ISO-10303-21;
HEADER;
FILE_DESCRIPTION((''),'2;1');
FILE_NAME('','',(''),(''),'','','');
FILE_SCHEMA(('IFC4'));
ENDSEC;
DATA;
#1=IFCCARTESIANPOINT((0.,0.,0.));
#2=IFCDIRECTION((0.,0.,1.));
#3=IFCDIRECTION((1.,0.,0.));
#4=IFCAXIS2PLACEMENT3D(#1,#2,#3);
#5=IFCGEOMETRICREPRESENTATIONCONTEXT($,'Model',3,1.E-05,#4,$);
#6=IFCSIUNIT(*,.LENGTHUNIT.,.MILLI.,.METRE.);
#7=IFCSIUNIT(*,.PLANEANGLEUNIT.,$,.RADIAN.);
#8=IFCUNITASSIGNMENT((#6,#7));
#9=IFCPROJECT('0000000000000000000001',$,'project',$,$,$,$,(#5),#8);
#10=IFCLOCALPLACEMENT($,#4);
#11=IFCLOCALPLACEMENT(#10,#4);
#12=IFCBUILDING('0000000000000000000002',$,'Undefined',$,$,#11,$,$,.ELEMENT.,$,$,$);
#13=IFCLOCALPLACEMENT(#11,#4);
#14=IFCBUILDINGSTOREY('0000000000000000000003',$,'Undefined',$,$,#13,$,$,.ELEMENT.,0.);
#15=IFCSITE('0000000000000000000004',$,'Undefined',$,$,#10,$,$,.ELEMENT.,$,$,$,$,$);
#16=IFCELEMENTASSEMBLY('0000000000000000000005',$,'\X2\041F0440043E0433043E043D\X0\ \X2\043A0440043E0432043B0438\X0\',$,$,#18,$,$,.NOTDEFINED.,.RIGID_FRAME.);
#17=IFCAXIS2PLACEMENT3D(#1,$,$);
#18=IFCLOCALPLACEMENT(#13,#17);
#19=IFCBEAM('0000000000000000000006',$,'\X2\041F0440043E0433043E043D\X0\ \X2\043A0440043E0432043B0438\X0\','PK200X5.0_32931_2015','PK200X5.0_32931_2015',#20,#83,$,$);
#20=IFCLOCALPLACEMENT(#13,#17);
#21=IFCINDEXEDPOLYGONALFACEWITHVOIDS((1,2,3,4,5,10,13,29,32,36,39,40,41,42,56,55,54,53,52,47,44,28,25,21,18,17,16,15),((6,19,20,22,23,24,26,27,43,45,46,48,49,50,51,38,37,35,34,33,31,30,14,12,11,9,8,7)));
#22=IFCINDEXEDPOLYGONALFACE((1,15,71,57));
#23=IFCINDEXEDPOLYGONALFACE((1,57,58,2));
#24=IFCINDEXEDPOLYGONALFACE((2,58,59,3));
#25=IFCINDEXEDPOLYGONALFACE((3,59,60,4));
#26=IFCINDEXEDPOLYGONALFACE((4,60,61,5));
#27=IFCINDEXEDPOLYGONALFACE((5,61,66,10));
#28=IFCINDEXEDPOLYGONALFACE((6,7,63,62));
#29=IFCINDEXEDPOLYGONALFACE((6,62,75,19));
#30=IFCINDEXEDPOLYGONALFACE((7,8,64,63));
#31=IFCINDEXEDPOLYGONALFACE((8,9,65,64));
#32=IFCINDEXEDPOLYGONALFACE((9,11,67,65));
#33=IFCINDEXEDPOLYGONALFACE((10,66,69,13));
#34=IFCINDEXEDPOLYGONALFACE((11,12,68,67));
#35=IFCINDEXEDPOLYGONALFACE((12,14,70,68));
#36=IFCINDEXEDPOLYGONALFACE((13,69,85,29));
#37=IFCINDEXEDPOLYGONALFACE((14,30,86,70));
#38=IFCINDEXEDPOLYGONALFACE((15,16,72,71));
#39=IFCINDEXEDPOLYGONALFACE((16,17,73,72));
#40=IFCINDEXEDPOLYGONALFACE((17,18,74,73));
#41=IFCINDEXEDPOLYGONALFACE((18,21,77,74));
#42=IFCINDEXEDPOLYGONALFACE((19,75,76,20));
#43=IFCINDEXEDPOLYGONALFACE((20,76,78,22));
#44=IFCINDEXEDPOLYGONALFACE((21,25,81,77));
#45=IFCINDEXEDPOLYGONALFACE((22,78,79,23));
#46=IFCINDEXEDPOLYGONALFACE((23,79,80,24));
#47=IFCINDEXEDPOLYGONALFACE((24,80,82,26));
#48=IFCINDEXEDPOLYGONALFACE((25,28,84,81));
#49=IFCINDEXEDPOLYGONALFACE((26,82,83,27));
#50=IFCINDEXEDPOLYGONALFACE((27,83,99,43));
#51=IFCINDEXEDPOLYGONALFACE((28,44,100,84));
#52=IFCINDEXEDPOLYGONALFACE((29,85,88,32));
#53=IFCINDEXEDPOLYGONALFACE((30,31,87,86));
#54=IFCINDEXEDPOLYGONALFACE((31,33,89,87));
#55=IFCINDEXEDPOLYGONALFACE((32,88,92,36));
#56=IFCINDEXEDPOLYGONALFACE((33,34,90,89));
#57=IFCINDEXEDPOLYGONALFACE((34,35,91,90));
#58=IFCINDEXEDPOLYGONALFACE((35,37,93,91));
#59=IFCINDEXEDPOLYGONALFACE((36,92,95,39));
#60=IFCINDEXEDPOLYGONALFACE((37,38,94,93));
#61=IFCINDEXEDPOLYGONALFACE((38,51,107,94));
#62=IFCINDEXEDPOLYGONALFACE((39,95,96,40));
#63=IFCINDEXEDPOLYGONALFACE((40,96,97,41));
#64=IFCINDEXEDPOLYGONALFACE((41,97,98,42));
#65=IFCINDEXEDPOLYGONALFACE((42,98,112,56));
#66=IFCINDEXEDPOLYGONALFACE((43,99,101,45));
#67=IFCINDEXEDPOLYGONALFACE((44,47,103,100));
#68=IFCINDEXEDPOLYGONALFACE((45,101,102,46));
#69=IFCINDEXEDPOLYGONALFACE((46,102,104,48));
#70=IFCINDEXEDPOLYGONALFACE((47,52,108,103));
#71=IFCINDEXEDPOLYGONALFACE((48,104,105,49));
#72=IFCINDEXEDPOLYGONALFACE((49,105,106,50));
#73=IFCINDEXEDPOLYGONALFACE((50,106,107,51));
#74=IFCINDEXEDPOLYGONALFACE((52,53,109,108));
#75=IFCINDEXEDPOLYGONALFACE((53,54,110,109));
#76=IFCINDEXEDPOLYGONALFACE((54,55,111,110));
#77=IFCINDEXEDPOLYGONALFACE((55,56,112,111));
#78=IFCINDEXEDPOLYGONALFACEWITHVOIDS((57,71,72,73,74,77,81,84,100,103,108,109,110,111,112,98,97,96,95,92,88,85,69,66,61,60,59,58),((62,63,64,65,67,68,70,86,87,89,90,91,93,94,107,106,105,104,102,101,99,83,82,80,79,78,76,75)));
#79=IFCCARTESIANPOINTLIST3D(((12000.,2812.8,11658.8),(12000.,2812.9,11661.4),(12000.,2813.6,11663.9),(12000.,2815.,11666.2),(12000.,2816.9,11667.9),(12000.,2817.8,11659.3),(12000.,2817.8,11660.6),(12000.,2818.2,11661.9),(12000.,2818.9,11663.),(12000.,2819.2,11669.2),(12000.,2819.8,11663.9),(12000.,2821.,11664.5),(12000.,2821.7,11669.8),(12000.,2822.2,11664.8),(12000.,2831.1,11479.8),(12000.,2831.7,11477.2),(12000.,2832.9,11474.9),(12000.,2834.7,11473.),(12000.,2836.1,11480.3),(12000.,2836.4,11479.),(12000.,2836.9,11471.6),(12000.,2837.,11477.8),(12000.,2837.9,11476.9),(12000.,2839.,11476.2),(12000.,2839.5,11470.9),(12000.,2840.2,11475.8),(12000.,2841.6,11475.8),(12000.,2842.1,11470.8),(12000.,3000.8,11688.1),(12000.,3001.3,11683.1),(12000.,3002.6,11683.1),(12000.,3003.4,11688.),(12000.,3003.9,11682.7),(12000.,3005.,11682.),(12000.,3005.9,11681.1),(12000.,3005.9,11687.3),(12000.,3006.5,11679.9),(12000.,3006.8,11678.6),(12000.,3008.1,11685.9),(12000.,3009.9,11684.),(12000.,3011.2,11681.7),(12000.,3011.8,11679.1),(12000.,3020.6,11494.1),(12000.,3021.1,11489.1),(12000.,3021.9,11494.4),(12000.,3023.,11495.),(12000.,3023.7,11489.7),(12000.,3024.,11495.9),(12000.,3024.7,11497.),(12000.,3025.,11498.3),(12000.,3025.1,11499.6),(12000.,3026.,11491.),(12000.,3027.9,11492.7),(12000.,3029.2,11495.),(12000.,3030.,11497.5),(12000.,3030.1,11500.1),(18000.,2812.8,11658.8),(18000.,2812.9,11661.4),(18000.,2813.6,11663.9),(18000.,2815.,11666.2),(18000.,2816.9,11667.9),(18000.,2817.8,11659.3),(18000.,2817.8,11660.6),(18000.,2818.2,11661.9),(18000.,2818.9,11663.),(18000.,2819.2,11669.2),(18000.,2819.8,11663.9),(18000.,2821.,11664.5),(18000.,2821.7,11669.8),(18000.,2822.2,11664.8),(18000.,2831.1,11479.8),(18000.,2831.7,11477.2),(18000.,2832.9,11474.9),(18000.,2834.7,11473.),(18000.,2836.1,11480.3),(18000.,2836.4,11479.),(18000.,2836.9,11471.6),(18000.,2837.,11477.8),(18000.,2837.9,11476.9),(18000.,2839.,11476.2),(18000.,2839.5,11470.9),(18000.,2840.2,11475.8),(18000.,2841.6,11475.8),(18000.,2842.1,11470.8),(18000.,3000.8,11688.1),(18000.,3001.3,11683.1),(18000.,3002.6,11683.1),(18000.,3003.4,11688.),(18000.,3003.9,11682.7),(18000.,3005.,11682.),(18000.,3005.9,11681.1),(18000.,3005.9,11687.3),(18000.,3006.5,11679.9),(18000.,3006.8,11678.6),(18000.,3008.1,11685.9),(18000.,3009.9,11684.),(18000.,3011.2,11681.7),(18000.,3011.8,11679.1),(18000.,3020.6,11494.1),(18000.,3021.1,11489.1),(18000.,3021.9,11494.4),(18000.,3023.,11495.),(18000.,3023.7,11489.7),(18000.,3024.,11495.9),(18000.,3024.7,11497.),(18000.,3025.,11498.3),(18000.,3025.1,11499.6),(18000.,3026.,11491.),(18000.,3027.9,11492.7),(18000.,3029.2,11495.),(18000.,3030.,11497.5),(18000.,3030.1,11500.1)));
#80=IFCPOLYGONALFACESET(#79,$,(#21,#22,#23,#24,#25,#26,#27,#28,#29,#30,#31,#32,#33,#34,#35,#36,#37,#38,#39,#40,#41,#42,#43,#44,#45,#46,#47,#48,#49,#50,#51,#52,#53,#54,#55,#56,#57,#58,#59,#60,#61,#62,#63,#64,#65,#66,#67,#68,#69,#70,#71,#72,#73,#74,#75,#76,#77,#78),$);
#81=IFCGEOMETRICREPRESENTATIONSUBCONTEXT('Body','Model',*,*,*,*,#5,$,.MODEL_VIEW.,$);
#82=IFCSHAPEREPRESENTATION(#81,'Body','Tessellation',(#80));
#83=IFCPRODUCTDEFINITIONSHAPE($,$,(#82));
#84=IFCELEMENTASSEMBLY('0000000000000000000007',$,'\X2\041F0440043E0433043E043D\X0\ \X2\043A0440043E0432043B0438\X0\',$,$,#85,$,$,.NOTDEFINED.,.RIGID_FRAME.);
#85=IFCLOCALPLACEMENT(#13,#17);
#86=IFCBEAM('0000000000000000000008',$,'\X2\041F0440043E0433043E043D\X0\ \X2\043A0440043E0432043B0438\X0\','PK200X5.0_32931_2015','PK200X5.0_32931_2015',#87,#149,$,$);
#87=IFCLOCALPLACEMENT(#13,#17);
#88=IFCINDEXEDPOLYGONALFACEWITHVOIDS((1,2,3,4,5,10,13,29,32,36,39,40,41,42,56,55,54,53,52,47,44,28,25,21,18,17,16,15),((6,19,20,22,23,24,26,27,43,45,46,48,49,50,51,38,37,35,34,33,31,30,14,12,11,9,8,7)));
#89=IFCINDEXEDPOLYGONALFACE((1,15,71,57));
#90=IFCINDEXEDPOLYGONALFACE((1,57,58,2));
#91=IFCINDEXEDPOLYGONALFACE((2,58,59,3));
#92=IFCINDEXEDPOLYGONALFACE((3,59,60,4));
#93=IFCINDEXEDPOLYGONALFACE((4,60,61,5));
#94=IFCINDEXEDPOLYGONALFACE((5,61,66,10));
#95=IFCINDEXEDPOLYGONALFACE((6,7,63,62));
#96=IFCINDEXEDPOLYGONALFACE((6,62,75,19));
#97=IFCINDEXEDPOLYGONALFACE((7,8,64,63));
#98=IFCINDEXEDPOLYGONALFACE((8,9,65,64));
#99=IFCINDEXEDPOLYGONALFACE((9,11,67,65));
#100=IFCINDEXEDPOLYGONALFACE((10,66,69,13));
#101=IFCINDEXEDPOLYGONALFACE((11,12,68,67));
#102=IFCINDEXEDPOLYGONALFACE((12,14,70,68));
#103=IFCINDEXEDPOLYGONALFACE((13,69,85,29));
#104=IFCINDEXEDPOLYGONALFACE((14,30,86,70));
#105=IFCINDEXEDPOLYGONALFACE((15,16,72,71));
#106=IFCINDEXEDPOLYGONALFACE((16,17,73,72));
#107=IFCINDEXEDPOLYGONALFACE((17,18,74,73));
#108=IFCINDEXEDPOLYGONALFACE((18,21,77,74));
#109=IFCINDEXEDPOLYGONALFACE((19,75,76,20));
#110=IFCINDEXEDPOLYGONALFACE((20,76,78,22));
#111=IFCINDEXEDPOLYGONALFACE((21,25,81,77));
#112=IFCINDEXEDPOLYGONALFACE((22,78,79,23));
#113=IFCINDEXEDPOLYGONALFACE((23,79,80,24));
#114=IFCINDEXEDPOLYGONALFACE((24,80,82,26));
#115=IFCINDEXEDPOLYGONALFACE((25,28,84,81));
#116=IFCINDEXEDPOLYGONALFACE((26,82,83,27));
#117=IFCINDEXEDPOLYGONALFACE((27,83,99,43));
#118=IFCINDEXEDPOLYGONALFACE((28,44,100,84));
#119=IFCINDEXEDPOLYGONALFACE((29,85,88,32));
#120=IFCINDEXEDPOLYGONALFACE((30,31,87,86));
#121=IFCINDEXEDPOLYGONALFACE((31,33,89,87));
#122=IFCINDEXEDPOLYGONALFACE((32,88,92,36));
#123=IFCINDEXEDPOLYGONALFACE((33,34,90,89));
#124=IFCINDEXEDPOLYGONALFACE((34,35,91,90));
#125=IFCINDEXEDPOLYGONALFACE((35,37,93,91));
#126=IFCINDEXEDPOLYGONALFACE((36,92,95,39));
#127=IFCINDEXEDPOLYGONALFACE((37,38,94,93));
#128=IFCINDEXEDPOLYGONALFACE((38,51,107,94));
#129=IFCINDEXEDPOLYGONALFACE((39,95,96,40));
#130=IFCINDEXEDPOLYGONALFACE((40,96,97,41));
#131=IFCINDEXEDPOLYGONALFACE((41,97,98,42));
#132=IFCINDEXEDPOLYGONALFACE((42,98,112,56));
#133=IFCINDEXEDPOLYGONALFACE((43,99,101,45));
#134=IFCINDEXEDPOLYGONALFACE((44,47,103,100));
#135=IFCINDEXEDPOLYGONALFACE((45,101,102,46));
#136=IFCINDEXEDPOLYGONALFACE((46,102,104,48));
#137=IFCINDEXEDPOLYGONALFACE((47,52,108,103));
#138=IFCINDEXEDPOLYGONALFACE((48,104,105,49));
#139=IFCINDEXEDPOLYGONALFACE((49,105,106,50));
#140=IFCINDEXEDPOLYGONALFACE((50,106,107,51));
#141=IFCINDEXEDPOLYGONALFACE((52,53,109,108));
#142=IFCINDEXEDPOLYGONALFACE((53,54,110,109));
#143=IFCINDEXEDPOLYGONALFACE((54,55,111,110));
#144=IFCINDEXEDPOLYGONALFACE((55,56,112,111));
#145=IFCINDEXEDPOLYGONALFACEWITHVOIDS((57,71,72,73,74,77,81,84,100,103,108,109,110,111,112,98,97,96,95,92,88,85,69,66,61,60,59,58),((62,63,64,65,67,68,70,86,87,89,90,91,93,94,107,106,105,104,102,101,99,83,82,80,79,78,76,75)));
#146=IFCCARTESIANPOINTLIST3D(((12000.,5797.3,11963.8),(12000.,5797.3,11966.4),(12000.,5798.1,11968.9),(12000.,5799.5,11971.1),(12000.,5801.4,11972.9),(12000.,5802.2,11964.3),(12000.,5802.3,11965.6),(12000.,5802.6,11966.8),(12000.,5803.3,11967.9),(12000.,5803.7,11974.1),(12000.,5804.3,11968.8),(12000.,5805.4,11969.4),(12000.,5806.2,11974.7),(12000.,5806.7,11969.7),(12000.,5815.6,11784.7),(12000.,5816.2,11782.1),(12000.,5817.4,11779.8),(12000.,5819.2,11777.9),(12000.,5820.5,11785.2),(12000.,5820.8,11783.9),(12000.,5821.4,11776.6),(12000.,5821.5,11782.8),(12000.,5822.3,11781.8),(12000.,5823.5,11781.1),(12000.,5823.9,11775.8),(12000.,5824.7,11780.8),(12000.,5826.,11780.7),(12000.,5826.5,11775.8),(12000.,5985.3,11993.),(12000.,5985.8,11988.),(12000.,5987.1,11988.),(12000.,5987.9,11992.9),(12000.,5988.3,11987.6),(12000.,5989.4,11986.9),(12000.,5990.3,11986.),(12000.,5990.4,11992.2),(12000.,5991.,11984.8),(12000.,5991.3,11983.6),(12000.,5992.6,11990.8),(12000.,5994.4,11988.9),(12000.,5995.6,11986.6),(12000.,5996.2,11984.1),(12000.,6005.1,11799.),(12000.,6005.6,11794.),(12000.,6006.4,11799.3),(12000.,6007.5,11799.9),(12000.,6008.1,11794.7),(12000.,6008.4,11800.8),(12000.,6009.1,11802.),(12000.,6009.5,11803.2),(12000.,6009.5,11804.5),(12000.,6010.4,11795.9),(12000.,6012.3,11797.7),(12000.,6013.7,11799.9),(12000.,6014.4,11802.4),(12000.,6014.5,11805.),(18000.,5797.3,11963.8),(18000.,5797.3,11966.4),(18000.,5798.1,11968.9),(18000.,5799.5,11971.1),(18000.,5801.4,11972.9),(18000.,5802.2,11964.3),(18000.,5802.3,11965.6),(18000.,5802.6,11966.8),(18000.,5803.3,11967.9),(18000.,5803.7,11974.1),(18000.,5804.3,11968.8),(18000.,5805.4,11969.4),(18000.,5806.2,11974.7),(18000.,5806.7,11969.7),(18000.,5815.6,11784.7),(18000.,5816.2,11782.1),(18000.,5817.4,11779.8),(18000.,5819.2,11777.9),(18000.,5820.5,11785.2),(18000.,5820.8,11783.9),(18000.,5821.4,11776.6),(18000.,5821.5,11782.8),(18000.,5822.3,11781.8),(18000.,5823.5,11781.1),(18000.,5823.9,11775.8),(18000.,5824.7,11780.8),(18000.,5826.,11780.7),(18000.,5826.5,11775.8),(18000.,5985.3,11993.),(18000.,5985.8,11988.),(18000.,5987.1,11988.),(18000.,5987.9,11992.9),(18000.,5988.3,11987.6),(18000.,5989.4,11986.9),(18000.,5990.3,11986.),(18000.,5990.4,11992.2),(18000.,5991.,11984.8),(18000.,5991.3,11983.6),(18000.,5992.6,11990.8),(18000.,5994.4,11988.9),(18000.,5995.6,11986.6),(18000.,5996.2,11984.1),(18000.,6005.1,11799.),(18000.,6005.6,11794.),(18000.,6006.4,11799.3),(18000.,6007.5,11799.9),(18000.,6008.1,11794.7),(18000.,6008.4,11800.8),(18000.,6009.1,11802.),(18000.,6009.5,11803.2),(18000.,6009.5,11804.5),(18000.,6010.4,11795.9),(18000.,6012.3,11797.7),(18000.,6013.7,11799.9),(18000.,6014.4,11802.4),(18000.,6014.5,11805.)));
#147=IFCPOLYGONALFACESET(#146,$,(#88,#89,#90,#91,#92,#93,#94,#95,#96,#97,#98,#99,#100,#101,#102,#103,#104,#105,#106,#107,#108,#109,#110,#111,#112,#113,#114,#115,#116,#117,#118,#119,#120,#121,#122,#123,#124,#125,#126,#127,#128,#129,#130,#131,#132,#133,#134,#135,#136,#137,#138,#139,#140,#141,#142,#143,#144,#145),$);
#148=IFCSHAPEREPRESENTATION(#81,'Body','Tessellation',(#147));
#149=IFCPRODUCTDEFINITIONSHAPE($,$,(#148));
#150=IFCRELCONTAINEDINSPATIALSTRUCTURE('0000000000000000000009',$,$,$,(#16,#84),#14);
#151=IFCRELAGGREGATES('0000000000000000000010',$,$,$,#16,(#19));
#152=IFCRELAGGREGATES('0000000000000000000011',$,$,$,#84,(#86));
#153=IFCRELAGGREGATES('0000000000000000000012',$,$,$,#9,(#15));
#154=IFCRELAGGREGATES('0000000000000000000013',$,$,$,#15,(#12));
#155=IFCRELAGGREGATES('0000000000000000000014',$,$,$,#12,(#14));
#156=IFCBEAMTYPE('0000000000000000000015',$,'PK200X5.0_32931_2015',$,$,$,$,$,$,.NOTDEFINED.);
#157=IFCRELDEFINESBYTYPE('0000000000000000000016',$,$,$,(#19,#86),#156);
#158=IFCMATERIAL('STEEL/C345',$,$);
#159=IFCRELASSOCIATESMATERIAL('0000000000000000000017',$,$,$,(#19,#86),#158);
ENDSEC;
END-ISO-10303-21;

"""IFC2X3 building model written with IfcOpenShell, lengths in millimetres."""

from ifc_helpers import new_model, si_unit, frame, origin_with_axes, origin_2d_with_axis, place, context, subcontext, project, spatial, hollow_rectangle, extrude, material, type_object, element, aggregate, save


model = new_model("IFC2X3")

# Units and contexts
model_context = context("Model", 3, precision=1e-05, world=origin_with_axes())
body_context = subcontext(model_context, "Body", "Model", "MODEL_VIEW")
ifc_project = project(units=[si_unit("LENGTHUNIT", "METRE", prefix="MILLI"), si_unit("PLANEANGLEUNIT", "RADIAN")], contexts=[model_context])

# Site, building, storey
site_placement = place(None, origin_with_axes())
site = spatial("IfcSite", under=ifc_project, at=site_placement, Name="Undefined", CompositionType="ELEMENT")
building_placement = place(site_placement, origin_with_axes())
building = spatial("IfcBuilding", under=site, at=building_placement, Name="Undefined", CompositionType="ELEMENT")
storey_placement = place(building_placement, origin_with_axes())
storey = spatial("IfcBuildingStorey", under=building, at=storey_placement, Name="Undefined", CompositionType="ELEMENT", Elevation=0.0)

# Element assemblies, beams
ifc_material_1 = material(Name="STEEL/C345")
beam_type_1 = type_object("IfcBeamType", Name="PK200X5.0_32931_2015", PredefinedType="NOTDEFINED")
assembly_1_placement = place(storey_placement, origin_with_axes())
assembly_1 = element("IfcElementAssembly", 1, at=assembly_1_placement, inside=storey, Name="Прогон кровли", AssemblyPlace="NOTDEFINED", PredefinedType="RIGID_FRAME")
beam_1_placement = place(assembly_1_placement, frame((18000.0, 2921.4, 11579.4), z_axis=(0.0, -0.101645, 0.994821), x_axis=(-1.0, 0.0, 0.0)))
beam_1 = element("IfcBeam", 2, at=beam_1_placement, type_object=beam_type_1, material=ifc_material_1, Name="Прогон кровли", Description="PK200X5.0_32931_2015", ObjectType="PK200X5.0_32931_2015", context=body_context, shape_type="SweptSolid", body=[
    extrude(hollow_rectangle(XDim=200.0, YDim=200.0, WallThickness=5.0, InnerFilletRadius=5.0, OuterFilletRadius=10.0, at=origin_2d_with_axis()), frame((6000.0, 0.0, 0.0), z_axis=(-1.0, 0.0, 0.0), x_axis=(0.0, -1.0, 0.0)), (0.0, 0.0, 1.0), 6000.0),
])
aggregate(assembly_1, [beam_1])
assembly_2_placement = place(storey_placement, origin_with_axes())
assembly_2 = element("IfcElementAssembly", 3, at=assembly_2_placement, inside=storey, Name="Прогон кровли", AssemblyPlace="NOTDEFINED", PredefinedType="RIGID_FRAME")
beam_2_placement = place(assembly_2_placement, frame((18000.0, 5905.9, 11884.4), z_axis=(0.0, -0.101645, 0.994821), x_axis=(-1.0, 0.0, 0.0)))
beam_2 = element("IfcBeam", 4, at=beam_2_placement, type_object=beam_type_1, material=ifc_material_1, Name="Прогон кровли", Description="PK200X5.0_32931_2015", ObjectType="PK200X5.0_32931_2015", context=body_context, shape_type="SweptSolid", body=[
    extrude(hollow_rectangle(XDim=200.0, YDim=200.0, WallThickness=5.0, InnerFilletRadius=5.0, OuterFilletRadius=10.0, at=origin_2d_with_axis()), frame((6000.0, 0.0, 0.0), z_axis=(-1.0, 0.0, 0.0), x_axis=(0.0, -1.0, 0.0)), (0.0, 0.0, 1.0), 6000.0),
])
aggregate(assembly_2, [beam_2])

save(model, "model.ifc")
